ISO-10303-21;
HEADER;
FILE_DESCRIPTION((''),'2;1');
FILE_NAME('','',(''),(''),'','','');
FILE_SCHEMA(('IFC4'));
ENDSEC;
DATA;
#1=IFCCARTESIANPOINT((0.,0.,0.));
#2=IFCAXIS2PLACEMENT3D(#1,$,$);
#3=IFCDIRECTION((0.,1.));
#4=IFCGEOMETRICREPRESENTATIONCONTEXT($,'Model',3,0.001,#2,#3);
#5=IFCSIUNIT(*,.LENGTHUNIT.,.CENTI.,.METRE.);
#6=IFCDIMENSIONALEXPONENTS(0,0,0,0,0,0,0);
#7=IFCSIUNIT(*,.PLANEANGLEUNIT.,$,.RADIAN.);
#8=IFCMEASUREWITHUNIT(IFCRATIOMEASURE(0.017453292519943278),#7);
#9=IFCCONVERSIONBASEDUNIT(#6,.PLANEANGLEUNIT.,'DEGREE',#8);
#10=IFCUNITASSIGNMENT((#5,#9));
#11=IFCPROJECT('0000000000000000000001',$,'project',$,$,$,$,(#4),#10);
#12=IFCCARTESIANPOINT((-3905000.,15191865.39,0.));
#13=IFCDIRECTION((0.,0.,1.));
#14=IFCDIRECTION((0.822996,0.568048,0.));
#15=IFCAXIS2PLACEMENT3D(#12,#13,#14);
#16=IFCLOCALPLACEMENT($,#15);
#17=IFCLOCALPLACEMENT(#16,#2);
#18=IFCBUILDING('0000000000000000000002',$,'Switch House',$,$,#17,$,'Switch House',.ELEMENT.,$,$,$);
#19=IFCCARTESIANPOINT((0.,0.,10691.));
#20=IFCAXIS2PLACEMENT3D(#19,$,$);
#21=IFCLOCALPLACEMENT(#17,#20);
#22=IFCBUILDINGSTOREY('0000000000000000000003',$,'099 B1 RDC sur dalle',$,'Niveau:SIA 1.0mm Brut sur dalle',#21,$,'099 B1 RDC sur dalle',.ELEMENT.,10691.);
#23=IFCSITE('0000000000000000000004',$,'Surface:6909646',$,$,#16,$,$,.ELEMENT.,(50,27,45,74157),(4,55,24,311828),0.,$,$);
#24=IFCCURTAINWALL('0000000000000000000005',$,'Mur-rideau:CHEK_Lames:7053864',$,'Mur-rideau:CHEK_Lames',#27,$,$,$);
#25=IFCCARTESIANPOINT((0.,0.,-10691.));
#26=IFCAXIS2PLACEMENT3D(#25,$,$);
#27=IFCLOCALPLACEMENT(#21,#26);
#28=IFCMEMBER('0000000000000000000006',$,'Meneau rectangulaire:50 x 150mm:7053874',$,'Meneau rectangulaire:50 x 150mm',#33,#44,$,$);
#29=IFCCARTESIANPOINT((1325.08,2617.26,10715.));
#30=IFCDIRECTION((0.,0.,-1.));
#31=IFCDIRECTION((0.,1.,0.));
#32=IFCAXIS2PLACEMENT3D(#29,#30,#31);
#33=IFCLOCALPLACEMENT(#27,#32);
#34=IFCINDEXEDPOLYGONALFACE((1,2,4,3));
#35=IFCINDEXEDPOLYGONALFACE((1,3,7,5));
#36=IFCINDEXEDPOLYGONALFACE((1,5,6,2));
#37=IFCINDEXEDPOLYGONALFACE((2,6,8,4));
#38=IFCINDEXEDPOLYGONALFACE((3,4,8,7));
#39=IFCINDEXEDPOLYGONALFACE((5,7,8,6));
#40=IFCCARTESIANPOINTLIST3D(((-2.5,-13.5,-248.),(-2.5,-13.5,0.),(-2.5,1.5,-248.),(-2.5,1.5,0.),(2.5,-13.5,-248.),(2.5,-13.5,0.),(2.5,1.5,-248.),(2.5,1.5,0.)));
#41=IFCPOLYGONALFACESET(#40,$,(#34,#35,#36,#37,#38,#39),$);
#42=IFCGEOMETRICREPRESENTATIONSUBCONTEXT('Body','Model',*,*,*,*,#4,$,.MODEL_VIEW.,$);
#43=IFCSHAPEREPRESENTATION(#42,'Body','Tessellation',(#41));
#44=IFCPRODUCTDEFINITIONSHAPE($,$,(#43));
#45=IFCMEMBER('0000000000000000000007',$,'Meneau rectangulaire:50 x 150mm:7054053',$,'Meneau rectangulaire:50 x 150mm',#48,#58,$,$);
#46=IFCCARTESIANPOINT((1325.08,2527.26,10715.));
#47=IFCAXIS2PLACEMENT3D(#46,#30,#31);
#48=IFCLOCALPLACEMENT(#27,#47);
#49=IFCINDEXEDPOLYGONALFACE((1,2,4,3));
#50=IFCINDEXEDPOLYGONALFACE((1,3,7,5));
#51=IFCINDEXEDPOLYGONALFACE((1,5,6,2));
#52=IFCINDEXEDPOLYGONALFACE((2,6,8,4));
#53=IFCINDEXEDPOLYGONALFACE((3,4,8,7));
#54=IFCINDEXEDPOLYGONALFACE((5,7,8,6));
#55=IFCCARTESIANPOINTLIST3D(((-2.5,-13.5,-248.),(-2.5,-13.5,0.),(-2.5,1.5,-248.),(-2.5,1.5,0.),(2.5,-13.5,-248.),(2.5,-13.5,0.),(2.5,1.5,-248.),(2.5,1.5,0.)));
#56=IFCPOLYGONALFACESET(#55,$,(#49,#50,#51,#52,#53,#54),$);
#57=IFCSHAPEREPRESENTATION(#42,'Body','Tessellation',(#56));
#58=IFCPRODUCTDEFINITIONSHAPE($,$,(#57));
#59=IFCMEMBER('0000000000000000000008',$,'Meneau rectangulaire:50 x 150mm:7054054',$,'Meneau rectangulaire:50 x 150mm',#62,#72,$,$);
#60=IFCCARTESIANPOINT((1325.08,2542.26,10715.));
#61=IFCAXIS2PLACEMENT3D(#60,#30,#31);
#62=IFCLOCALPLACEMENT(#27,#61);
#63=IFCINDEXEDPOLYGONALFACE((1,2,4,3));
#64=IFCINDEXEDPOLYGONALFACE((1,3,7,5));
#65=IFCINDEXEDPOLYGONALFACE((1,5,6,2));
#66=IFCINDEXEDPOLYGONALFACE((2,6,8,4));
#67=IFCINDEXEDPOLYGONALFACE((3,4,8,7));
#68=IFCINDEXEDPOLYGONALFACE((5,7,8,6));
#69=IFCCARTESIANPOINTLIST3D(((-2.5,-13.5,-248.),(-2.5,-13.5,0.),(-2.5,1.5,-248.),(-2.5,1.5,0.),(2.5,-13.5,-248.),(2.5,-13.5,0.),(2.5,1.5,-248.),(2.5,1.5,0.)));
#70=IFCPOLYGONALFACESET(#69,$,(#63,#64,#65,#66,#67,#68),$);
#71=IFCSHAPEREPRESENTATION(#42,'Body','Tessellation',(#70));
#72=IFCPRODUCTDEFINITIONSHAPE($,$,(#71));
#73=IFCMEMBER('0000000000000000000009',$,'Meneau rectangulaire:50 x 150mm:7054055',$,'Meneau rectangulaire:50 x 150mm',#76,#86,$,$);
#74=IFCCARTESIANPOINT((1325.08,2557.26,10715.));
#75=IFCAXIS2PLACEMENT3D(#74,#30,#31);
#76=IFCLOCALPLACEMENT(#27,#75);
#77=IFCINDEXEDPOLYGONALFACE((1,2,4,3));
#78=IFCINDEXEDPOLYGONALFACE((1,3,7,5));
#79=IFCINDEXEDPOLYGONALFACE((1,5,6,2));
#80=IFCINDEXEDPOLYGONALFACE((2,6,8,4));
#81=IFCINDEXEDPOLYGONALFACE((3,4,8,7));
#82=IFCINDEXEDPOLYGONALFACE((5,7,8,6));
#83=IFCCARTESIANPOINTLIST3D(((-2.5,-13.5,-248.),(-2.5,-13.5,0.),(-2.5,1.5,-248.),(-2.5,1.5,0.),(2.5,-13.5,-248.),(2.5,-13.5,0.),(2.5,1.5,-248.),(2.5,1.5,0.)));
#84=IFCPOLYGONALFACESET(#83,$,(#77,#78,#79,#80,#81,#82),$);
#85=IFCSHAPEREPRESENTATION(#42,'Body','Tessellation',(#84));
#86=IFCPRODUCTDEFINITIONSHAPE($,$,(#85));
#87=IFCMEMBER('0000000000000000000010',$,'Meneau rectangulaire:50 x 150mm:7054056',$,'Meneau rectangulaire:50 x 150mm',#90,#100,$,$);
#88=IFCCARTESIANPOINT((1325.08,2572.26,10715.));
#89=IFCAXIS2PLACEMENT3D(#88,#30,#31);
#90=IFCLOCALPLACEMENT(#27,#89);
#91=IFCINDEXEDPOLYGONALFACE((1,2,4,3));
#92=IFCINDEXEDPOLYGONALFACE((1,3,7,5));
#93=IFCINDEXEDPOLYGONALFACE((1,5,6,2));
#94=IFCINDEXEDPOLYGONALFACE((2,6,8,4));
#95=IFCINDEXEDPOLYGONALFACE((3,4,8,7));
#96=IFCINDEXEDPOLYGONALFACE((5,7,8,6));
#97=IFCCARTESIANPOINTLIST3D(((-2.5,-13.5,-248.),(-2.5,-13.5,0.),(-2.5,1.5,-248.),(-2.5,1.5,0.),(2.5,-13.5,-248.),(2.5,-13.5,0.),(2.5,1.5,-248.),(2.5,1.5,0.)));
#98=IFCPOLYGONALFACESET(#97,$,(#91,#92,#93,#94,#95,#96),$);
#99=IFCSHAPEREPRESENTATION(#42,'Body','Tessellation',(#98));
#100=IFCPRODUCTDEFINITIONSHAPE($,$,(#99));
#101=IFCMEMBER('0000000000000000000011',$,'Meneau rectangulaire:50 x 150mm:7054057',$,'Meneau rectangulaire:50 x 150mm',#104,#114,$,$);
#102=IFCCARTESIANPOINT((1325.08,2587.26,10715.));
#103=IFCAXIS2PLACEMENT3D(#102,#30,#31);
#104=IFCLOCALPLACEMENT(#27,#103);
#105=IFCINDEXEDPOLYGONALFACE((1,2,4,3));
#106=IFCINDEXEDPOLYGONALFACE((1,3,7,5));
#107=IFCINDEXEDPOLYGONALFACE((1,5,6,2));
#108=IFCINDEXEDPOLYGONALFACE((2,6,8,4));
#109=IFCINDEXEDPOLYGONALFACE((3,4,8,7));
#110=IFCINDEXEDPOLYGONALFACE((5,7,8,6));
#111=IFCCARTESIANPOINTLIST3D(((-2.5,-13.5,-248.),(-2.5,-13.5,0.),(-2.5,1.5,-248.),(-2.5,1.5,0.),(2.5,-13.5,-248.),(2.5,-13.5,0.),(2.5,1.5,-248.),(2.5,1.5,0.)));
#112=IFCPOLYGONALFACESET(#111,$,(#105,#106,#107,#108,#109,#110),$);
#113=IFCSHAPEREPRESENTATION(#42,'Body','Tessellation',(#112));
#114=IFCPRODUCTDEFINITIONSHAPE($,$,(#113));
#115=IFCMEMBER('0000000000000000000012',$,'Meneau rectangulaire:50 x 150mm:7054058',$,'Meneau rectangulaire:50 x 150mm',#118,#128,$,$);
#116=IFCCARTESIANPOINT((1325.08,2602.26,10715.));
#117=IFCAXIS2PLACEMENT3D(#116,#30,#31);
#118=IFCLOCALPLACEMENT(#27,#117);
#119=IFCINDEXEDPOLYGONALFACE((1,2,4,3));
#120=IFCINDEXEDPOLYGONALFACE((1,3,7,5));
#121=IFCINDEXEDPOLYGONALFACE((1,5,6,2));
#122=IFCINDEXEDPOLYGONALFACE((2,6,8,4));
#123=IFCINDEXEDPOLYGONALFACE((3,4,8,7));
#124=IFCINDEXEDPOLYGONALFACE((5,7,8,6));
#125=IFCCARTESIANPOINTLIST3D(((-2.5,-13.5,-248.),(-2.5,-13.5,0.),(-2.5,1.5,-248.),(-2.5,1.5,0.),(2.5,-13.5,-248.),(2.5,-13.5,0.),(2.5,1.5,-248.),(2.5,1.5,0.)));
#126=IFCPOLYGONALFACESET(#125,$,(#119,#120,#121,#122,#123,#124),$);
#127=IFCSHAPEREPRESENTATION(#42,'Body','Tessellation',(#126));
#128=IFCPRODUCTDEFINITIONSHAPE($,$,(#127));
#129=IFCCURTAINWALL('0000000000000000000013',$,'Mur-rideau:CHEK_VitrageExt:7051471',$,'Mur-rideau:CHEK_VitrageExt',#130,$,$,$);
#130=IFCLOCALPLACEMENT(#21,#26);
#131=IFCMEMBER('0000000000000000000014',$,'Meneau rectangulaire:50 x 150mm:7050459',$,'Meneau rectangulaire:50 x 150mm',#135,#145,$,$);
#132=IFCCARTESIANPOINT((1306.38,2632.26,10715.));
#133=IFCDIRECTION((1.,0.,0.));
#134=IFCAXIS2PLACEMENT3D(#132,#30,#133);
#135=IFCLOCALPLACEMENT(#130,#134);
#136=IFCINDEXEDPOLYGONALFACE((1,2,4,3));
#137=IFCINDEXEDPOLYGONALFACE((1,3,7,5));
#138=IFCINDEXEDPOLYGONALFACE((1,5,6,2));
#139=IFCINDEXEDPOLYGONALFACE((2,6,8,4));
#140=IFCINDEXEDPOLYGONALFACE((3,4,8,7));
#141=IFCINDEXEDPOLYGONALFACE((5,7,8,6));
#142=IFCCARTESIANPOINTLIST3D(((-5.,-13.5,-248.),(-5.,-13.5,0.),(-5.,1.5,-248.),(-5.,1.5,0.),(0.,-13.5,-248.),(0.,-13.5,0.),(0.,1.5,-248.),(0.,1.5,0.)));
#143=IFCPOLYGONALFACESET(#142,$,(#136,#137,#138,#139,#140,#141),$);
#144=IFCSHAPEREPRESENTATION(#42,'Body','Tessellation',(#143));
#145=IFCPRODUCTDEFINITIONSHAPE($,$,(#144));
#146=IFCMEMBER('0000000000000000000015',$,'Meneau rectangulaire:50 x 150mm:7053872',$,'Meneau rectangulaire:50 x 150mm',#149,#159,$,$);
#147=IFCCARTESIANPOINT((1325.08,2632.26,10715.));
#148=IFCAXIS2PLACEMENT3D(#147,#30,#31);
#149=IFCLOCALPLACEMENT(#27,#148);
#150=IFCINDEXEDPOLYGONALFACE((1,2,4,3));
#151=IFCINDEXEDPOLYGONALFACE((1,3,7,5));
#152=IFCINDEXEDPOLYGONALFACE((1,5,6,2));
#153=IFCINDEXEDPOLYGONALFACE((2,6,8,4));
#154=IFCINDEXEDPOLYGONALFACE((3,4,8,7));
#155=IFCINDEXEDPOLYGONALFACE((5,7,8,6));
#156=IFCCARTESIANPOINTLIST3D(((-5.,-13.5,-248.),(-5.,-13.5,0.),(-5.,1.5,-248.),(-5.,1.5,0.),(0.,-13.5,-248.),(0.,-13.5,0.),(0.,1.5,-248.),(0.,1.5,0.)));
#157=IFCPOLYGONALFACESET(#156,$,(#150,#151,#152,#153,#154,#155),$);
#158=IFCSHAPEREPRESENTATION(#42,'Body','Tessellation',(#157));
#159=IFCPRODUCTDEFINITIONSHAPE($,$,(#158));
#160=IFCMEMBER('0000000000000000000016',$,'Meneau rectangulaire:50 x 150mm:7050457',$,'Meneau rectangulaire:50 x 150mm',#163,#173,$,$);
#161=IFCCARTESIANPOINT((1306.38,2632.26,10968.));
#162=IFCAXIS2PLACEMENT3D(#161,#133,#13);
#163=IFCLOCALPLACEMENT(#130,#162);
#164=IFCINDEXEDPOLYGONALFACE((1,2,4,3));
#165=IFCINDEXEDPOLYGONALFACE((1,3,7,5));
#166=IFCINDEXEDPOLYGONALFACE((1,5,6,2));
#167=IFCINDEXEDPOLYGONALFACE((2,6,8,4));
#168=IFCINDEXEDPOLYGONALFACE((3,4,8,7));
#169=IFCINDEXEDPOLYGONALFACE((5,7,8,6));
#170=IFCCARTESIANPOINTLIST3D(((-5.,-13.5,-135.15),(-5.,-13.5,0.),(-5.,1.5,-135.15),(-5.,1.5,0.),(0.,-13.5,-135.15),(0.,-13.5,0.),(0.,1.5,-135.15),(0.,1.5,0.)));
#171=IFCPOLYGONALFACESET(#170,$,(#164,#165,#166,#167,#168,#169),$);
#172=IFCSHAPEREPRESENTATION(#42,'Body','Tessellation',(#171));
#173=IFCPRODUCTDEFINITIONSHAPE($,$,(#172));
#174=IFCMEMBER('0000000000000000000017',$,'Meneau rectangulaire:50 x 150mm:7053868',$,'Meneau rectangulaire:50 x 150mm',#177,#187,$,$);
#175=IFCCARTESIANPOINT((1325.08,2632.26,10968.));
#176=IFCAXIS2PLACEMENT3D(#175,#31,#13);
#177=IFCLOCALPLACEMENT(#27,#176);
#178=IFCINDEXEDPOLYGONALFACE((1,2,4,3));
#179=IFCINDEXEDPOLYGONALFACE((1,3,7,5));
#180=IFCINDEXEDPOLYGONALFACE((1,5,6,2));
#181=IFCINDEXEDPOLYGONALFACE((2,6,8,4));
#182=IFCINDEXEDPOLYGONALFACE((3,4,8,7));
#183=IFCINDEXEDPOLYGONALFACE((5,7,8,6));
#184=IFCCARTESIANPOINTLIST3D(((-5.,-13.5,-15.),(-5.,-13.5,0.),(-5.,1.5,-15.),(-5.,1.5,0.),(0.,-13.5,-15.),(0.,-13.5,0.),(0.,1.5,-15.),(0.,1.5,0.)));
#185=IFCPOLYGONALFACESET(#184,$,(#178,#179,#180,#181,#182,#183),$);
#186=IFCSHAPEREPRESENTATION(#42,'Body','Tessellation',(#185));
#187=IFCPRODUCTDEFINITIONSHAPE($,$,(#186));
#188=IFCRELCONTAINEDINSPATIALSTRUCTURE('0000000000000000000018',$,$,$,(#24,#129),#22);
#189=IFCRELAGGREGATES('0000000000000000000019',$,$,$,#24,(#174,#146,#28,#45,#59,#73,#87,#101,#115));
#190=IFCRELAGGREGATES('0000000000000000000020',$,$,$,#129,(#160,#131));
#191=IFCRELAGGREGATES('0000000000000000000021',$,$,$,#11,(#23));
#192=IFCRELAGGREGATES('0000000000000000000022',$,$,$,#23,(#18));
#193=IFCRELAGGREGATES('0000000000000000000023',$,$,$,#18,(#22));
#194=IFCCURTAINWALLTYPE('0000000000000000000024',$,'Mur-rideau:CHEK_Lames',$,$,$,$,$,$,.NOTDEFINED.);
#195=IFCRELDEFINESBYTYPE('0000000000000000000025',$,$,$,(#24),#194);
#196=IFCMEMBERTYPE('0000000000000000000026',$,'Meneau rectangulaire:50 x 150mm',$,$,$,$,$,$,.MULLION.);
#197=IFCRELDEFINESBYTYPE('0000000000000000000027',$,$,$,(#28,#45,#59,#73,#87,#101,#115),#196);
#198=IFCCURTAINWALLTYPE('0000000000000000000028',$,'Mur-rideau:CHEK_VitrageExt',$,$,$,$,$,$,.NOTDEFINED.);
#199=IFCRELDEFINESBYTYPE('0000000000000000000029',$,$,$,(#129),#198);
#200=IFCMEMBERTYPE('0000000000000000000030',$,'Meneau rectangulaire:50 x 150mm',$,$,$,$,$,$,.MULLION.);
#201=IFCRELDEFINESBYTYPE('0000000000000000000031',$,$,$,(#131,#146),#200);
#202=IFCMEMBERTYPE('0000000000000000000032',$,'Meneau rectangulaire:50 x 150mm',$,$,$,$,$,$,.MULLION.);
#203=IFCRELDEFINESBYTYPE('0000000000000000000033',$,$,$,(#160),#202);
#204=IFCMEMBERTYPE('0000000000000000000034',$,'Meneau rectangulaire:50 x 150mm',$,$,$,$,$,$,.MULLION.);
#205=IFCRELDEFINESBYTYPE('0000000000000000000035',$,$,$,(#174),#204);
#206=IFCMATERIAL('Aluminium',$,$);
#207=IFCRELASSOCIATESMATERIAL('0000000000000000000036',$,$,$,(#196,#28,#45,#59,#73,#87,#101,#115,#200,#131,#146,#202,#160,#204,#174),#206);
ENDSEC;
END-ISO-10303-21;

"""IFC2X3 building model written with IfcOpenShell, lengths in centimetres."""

from ifc_helpers import new_model, entity, si_unit, converted_unit, direction, frame, origin, origin_2d_with_axis, place, context, subcontext, project, spatial, rectangle, extrude, source, transform, mapped, material, type_object, type_shapes, element, aggregate, save


model = new_model("IFC2X3")

# Units and contexts
model_context = context("Model", 3, precision=0.001, world=origin(), true_north=direction((0.0, 1.0)))
body_context = subcontext(model_context, "Body", "Model", "MODEL_VIEW")
ifc_project = project(units=[si_unit("LENGTHUNIT", "METRE", prefix="CENTI"), converted_unit("PLANEANGLEUNIT", "DEGREE", entity("IfcRatioMeasure", 0.017453292519943278), si_unit("PLANEANGLEUNIT", "RADIAN"), dimensions=[0, 0, 0, 0, 0, 0, 0])], contexts=[model_context])

# Site, building, storey
site_placement = place(None, frame((-3905000.0, 15191865.39, 0.0), z_axis=(0.0, 0.0, 1.0), x_axis=(0.822996, 0.568048, 0.0)))
site = spatial("IfcSite", under=ifc_project, at=site_placement, Name="Surface:6909646", CompositionType="ELEMENT", RefLatitude=(50, 27, 45, 74157), RefLongitude=(4, 55, 24, 311828), RefElevation=0.0)
building_placement = place(site_placement, origin())
building = spatial("IfcBuilding", under=site, at=building_placement, Name="Switch House", LongName="Switch House", CompositionType="ELEMENT")
storey_placement = place(building_placement, frame((0.0, 0.0, 10691.0)))
storey = spatial("IfcBuildingStorey", under=building, at=storey_placement, Name="099 B1 RDC sur dalle", ObjectType="Niveau:SIA 1.0mm Brut sur dalle", LongName="099 B1 RDC sur dalle", CompositionType="ELEMENT", Elevation=10691.0)

# Curtain wall, members
curtain_wall_type_1 = type_object("IfcCurtainWallType", Name="Mur-rideau:CHEK_Lames", PredefinedType="NOTDEFINED")
curtain_wall_1_placement = place(storey_placement, frame((0.0, 0.0, -10691.0)))
curtain_wall_1 = element("IfcCurtainWall", 1, at=curtain_wall_1_placement, inside=storey, type_object=curtain_wall_type_1, Name="Mur-rideau:CHEK_Lames:7053864", ObjectType="Mur-rideau:CHEK_Lames")
ifc_material_1 = material(Name="Aluminium")
member_type_1 = type_object("IfcMemberType", Name="Meneau rectangulaire:50 x 150mm", PredefinedType="MULLION", material=ifc_material_1)
shared_shape_1 = source(origin(), body_context, "Body", "SweptSolid", [
    extrude(rectangle(XDim=15.0, YDim=5.0, at=origin_2d_with_axis()), frame((0.0, -6.0, -248.0), z_axis=(0.0, 0.0, 1.0), x_axis=(0.0, -1.0, 0.0)), (0.0, 0.0, 1.0), 248.0),
])
type_shapes(member_type_1, [shared_shape_1])
member_1_placement = place(curtain_wall_1_placement, frame((1325.08, 2617.26, 10715.0), z_axis=(0.0, 0.0, -1.0), x_axis=(0.0, 1.0, 0.0)))
member_1 = element("IfcMember", 2, at=member_1_placement, type_object=member_type_1, material=ifc_material_1, Name="Meneau rectangulaire:50 x 150mm:7053874", ObjectType="Meneau rectangulaire:50 x 150mm", context=body_context, shape_type="MappedRepresentation", body=[
    mapped(shared_shape_1, transform((0.0, 0.0, 0.0), scale=1.0)),
])
member_2_placement = place(curtain_wall_1_placement, frame((1325.08, 2527.26, 10715.0), z_axis=(0.0, 0.0, -1.0), x_axis=(0.0, 1.0, 0.0)))
member_2 = element("IfcMember", 3, at=member_2_placement, type_object=member_type_1, material=ifc_material_1, Name="Meneau rectangulaire:50 x 150mm:7054053", ObjectType="Meneau rectangulaire:50 x 150mm", context=body_context, shape_type="MappedRepresentation", body=[
    mapped(shared_shape_1, transform((0.0, 0.0, 0.0), scale=1.0)),
])
member_3_placement = place(curtain_wall_1_placement, frame((1325.08, 2542.26, 10715.0), z_axis=(0.0, 0.0, -1.0), x_axis=(0.0, 1.0, 0.0)))
member_3 = element("IfcMember", 4, at=member_3_placement, type_object=member_type_1, material=ifc_material_1, Name="Meneau rectangulaire:50 x 150mm:7054054", ObjectType="Meneau rectangulaire:50 x 150mm", context=body_context, shape_type="MappedRepresentation", body=[
    mapped(shared_shape_1, transform((0.0, 0.0, 0.0), scale=1.0)),
])
member_4_placement = place(curtain_wall_1_placement, frame((1325.08, 2557.26, 10715.0), z_axis=(0.0, 0.0, -1.0), x_axis=(0.0, 1.0, 0.0)))
member_4 = element("IfcMember", 5, at=member_4_placement, type_object=member_type_1, material=ifc_material_1, Name="Meneau rectangulaire:50 x 150mm:7054055", ObjectType="Meneau rectangulaire:50 x 150mm", context=body_context, shape_type="MappedRepresentation", body=[
    mapped(shared_shape_1, transform((0.0, 0.0, 0.0), scale=1.0)),
])
member_5_placement = place(curtain_wall_1_placement, frame((1325.08, 2572.26, 10715.0), z_axis=(0.0, 0.0, -1.0), x_axis=(0.0, 1.0, 0.0)))
member_5 = element("IfcMember", 6, at=member_5_placement, type_object=member_type_1, material=ifc_material_1, Name="Meneau rectangulaire:50 x 150mm:7054056", ObjectType="Meneau rectangulaire:50 x 150mm", context=body_context, shape_type="MappedRepresentation", body=[
    mapped(shared_shape_1, transform((0.0, 0.0, 0.0), scale=1.0)),
])
member_6_placement = place(curtain_wall_1_placement, frame((1325.08, 2587.26, 10715.0), z_axis=(0.0, 0.0, -1.0), x_axis=(0.0, 1.0, 0.0)))
member_6 = element("IfcMember", 7, at=member_6_placement, type_object=member_type_1, material=ifc_material_1, Name="Meneau rectangulaire:50 x 150mm:7054057", ObjectType="Meneau rectangulaire:50 x 150mm", context=body_context, shape_type="MappedRepresentation", body=[
    mapped(shared_shape_1, transform((0.0, 0.0, 0.0), scale=1.0)),
])
member_7_placement = place(curtain_wall_1_placement, frame((1325.08, 2602.26, 10715.0), z_axis=(0.0, 0.0, -1.0), x_axis=(0.0, 1.0, 0.0)))
member_7 = element("IfcMember", 8, at=member_7_placement, type_object=member_type_1, material=ifc_material_1, Name="Meneau rectangulaire:50 x 150mm:7054058", ObjectType="Meneau rectangulaire:50 x 150mm", context=body_context, shape_type="MappedRepresentation", body=[
    mapped(shared_shape_1, transform((0.0, 0.0, 0.0), scale=1.0)),
])

# Curtain wall, member
curtain_wall_type_2 = type_object("IfcCurtainWallType", Name="Mur-rideau:CHEK_VitrageExt", PredefinedType="NOTDEFINED")
curtain_wall_2_placement = place(storey_placement, frame((0.0, 0.0, -10691.0)))
curtain_wall_2 = element("IfcCurtainWall", 9, at=curtain_wall_2_placement, inside=storey, type_object=curtain_wall_type_2, Name="Mur-rideau:CHEK_VitrageExt:7051471", ObjectType="Mur-rideau:CHEK_VitrageExt")
member_type_2 = type_object("IfcMemberType", Name="Meneau rectangulaire:50 x 150mm", PredefinedType="MULLION", material=ifc_material_1)
shared_shape_2 = source(origin(), body_context, "Body", "SweptSolid", [
    extrude(rectangle(XDim=15.0, YDim=5.0, at=origin_2d_with_axis()), frame((-2.5, -6.0, -248.0), z_axis=(0.0, 0.0, 1.0), x_axis=(0.0, -1.0, 0.0)), (0.0, 0.0, 1.0), 248.0),
])
type_shapes(member_type_2, [shared_shape_2])
member_8_placement = place(curtain_wall_2_placement, frame((1306.38, 2632.26, 10715.0), z_axis=(0.0, 0.0, -1.0), x_axis=(1.0, 0.0, 0.0)))
member_8 = element("IfcMember", 10, at=member_8_placement, type_object=member_type_2, material=ifc_material_1, Name="Meneau rectangulaire:50 x 150mm:7050459", ObjectType="Meneau rectangulaire:50 x 150mm", context=body_context, shape_type="MappedRepresentation", body=[
    mapped(shared_shape_2, transform((0.0, 0.0, 0.0), scale=1.0)),
])

# Members
member_9_placement = place(curtain_wall_1_placement, frame((1325.08, 2632.26, 10715.0), z_axis=(0.0, 0.0, -1.0), x_axis=(0.0, 1.0, 0.0)))
member_9 = element("IfcMember", 11, at=member_9_placement, type_object=member_type_2, material=ifc_material_1, Name="Meneau rectangulaire:50 x 150mm:7053872", ObjectType="Meneau rectangulaire:50 x 150mm", context=body_context, shape_type="MappedRepresentation", body=[
    mapped(shared_shape_2, transform((0.0, 0.0, 0.0), scale=1.0)),
])
member_type_3 = type_object("IfcMemberType", Name="Meneau rectangulaire:50 x 150mm", PredefinedType="MULLION", material=ifc_material_1)
shared_shape_3 = source(origin(), body_context, "Body", "SweptSolid", [
    extrude(rectangle(XDim=15.0, YDim=5.0, at=origin_2d_with_axis()), frame((-2.5, -6.0, -135.15), z_axis=(0.0, 0.0, 1.0), x_axis=(0.0, -1.0, 0.0)), (0.0, 0.0, 1.0), 135.15),
])
type_shapes(member_type_3, [shared_shape_3])
member_10_placement = place(curtain_wall_2_placement, frame((1306.38, 2632.26, 10968.0), z_axis=(1.0, 0.0, 0.0), x_axis=(0.0, 0.0, 1.0)))
member_10 = element("IfcMember", 12, at=member_10_placement, type_object=member_type_3, material=ifc_material_1, Name="Meneau rectangulaire:50 x 150mm:7050457", ObjectType="Meneau rectangulaire:50 x 150mm", context=body_context, shape_type="MappedRepresentation", body=[
    mapped(shared_shape_3, transform((0.0, 0.0, 0.0), scale=1.0)),
])
member_type_4 = type_object("IfcMemberType", Name="Meneau rectangulaire:50 x 150mm", PredefinedType="MULLION", material=ifc_material_1)
shared_shape_4 = source(origin(), body_context, "Body", "SweptSolid", [
    extrude(rectangle(XDim=15.0, YDim=5.0, at=origin_2d_with_axis()), frame((-2.5, -6.0, -15.0), z_axis=(0.0, 0.0, 1.0), x_axis=(0.0, -1.0, 0.0)), (0.0, 0.0, 1.0), 15.0),
])
type_shapes(member_type_4, [shared_shape_4])
member_11_placement = place(curtain_wall_1_placement, frame((1325.08, 2632.26, 10968.0), z_axis=(0.0, 1.0, 0.0), x_axis=(0.0, 0.0, 1.0)))
member_11 = element("IfcMember", 13, at=member_11_placement, type_object=member_type_4, material=ifc_material_1, Name="Meneau rectangulaire:50 x 150mm:7053868", ObjectType="Meneau rectangulaire:50 x 150mm", context=body_context, shape_type="MappedRepresentation", body=[
    mapped(shared_shape_4, transform((0.0, 0.0, 0.0), scale=1.0)),
])
aggregate(curtain_wall_1, [member_11, member_9, member_1, member_2, member_3, member_4, member_5, member_6, member_7])

aggregate(curtain_wall_2, [member_10, member_8])

save(model, "model.ifc")
